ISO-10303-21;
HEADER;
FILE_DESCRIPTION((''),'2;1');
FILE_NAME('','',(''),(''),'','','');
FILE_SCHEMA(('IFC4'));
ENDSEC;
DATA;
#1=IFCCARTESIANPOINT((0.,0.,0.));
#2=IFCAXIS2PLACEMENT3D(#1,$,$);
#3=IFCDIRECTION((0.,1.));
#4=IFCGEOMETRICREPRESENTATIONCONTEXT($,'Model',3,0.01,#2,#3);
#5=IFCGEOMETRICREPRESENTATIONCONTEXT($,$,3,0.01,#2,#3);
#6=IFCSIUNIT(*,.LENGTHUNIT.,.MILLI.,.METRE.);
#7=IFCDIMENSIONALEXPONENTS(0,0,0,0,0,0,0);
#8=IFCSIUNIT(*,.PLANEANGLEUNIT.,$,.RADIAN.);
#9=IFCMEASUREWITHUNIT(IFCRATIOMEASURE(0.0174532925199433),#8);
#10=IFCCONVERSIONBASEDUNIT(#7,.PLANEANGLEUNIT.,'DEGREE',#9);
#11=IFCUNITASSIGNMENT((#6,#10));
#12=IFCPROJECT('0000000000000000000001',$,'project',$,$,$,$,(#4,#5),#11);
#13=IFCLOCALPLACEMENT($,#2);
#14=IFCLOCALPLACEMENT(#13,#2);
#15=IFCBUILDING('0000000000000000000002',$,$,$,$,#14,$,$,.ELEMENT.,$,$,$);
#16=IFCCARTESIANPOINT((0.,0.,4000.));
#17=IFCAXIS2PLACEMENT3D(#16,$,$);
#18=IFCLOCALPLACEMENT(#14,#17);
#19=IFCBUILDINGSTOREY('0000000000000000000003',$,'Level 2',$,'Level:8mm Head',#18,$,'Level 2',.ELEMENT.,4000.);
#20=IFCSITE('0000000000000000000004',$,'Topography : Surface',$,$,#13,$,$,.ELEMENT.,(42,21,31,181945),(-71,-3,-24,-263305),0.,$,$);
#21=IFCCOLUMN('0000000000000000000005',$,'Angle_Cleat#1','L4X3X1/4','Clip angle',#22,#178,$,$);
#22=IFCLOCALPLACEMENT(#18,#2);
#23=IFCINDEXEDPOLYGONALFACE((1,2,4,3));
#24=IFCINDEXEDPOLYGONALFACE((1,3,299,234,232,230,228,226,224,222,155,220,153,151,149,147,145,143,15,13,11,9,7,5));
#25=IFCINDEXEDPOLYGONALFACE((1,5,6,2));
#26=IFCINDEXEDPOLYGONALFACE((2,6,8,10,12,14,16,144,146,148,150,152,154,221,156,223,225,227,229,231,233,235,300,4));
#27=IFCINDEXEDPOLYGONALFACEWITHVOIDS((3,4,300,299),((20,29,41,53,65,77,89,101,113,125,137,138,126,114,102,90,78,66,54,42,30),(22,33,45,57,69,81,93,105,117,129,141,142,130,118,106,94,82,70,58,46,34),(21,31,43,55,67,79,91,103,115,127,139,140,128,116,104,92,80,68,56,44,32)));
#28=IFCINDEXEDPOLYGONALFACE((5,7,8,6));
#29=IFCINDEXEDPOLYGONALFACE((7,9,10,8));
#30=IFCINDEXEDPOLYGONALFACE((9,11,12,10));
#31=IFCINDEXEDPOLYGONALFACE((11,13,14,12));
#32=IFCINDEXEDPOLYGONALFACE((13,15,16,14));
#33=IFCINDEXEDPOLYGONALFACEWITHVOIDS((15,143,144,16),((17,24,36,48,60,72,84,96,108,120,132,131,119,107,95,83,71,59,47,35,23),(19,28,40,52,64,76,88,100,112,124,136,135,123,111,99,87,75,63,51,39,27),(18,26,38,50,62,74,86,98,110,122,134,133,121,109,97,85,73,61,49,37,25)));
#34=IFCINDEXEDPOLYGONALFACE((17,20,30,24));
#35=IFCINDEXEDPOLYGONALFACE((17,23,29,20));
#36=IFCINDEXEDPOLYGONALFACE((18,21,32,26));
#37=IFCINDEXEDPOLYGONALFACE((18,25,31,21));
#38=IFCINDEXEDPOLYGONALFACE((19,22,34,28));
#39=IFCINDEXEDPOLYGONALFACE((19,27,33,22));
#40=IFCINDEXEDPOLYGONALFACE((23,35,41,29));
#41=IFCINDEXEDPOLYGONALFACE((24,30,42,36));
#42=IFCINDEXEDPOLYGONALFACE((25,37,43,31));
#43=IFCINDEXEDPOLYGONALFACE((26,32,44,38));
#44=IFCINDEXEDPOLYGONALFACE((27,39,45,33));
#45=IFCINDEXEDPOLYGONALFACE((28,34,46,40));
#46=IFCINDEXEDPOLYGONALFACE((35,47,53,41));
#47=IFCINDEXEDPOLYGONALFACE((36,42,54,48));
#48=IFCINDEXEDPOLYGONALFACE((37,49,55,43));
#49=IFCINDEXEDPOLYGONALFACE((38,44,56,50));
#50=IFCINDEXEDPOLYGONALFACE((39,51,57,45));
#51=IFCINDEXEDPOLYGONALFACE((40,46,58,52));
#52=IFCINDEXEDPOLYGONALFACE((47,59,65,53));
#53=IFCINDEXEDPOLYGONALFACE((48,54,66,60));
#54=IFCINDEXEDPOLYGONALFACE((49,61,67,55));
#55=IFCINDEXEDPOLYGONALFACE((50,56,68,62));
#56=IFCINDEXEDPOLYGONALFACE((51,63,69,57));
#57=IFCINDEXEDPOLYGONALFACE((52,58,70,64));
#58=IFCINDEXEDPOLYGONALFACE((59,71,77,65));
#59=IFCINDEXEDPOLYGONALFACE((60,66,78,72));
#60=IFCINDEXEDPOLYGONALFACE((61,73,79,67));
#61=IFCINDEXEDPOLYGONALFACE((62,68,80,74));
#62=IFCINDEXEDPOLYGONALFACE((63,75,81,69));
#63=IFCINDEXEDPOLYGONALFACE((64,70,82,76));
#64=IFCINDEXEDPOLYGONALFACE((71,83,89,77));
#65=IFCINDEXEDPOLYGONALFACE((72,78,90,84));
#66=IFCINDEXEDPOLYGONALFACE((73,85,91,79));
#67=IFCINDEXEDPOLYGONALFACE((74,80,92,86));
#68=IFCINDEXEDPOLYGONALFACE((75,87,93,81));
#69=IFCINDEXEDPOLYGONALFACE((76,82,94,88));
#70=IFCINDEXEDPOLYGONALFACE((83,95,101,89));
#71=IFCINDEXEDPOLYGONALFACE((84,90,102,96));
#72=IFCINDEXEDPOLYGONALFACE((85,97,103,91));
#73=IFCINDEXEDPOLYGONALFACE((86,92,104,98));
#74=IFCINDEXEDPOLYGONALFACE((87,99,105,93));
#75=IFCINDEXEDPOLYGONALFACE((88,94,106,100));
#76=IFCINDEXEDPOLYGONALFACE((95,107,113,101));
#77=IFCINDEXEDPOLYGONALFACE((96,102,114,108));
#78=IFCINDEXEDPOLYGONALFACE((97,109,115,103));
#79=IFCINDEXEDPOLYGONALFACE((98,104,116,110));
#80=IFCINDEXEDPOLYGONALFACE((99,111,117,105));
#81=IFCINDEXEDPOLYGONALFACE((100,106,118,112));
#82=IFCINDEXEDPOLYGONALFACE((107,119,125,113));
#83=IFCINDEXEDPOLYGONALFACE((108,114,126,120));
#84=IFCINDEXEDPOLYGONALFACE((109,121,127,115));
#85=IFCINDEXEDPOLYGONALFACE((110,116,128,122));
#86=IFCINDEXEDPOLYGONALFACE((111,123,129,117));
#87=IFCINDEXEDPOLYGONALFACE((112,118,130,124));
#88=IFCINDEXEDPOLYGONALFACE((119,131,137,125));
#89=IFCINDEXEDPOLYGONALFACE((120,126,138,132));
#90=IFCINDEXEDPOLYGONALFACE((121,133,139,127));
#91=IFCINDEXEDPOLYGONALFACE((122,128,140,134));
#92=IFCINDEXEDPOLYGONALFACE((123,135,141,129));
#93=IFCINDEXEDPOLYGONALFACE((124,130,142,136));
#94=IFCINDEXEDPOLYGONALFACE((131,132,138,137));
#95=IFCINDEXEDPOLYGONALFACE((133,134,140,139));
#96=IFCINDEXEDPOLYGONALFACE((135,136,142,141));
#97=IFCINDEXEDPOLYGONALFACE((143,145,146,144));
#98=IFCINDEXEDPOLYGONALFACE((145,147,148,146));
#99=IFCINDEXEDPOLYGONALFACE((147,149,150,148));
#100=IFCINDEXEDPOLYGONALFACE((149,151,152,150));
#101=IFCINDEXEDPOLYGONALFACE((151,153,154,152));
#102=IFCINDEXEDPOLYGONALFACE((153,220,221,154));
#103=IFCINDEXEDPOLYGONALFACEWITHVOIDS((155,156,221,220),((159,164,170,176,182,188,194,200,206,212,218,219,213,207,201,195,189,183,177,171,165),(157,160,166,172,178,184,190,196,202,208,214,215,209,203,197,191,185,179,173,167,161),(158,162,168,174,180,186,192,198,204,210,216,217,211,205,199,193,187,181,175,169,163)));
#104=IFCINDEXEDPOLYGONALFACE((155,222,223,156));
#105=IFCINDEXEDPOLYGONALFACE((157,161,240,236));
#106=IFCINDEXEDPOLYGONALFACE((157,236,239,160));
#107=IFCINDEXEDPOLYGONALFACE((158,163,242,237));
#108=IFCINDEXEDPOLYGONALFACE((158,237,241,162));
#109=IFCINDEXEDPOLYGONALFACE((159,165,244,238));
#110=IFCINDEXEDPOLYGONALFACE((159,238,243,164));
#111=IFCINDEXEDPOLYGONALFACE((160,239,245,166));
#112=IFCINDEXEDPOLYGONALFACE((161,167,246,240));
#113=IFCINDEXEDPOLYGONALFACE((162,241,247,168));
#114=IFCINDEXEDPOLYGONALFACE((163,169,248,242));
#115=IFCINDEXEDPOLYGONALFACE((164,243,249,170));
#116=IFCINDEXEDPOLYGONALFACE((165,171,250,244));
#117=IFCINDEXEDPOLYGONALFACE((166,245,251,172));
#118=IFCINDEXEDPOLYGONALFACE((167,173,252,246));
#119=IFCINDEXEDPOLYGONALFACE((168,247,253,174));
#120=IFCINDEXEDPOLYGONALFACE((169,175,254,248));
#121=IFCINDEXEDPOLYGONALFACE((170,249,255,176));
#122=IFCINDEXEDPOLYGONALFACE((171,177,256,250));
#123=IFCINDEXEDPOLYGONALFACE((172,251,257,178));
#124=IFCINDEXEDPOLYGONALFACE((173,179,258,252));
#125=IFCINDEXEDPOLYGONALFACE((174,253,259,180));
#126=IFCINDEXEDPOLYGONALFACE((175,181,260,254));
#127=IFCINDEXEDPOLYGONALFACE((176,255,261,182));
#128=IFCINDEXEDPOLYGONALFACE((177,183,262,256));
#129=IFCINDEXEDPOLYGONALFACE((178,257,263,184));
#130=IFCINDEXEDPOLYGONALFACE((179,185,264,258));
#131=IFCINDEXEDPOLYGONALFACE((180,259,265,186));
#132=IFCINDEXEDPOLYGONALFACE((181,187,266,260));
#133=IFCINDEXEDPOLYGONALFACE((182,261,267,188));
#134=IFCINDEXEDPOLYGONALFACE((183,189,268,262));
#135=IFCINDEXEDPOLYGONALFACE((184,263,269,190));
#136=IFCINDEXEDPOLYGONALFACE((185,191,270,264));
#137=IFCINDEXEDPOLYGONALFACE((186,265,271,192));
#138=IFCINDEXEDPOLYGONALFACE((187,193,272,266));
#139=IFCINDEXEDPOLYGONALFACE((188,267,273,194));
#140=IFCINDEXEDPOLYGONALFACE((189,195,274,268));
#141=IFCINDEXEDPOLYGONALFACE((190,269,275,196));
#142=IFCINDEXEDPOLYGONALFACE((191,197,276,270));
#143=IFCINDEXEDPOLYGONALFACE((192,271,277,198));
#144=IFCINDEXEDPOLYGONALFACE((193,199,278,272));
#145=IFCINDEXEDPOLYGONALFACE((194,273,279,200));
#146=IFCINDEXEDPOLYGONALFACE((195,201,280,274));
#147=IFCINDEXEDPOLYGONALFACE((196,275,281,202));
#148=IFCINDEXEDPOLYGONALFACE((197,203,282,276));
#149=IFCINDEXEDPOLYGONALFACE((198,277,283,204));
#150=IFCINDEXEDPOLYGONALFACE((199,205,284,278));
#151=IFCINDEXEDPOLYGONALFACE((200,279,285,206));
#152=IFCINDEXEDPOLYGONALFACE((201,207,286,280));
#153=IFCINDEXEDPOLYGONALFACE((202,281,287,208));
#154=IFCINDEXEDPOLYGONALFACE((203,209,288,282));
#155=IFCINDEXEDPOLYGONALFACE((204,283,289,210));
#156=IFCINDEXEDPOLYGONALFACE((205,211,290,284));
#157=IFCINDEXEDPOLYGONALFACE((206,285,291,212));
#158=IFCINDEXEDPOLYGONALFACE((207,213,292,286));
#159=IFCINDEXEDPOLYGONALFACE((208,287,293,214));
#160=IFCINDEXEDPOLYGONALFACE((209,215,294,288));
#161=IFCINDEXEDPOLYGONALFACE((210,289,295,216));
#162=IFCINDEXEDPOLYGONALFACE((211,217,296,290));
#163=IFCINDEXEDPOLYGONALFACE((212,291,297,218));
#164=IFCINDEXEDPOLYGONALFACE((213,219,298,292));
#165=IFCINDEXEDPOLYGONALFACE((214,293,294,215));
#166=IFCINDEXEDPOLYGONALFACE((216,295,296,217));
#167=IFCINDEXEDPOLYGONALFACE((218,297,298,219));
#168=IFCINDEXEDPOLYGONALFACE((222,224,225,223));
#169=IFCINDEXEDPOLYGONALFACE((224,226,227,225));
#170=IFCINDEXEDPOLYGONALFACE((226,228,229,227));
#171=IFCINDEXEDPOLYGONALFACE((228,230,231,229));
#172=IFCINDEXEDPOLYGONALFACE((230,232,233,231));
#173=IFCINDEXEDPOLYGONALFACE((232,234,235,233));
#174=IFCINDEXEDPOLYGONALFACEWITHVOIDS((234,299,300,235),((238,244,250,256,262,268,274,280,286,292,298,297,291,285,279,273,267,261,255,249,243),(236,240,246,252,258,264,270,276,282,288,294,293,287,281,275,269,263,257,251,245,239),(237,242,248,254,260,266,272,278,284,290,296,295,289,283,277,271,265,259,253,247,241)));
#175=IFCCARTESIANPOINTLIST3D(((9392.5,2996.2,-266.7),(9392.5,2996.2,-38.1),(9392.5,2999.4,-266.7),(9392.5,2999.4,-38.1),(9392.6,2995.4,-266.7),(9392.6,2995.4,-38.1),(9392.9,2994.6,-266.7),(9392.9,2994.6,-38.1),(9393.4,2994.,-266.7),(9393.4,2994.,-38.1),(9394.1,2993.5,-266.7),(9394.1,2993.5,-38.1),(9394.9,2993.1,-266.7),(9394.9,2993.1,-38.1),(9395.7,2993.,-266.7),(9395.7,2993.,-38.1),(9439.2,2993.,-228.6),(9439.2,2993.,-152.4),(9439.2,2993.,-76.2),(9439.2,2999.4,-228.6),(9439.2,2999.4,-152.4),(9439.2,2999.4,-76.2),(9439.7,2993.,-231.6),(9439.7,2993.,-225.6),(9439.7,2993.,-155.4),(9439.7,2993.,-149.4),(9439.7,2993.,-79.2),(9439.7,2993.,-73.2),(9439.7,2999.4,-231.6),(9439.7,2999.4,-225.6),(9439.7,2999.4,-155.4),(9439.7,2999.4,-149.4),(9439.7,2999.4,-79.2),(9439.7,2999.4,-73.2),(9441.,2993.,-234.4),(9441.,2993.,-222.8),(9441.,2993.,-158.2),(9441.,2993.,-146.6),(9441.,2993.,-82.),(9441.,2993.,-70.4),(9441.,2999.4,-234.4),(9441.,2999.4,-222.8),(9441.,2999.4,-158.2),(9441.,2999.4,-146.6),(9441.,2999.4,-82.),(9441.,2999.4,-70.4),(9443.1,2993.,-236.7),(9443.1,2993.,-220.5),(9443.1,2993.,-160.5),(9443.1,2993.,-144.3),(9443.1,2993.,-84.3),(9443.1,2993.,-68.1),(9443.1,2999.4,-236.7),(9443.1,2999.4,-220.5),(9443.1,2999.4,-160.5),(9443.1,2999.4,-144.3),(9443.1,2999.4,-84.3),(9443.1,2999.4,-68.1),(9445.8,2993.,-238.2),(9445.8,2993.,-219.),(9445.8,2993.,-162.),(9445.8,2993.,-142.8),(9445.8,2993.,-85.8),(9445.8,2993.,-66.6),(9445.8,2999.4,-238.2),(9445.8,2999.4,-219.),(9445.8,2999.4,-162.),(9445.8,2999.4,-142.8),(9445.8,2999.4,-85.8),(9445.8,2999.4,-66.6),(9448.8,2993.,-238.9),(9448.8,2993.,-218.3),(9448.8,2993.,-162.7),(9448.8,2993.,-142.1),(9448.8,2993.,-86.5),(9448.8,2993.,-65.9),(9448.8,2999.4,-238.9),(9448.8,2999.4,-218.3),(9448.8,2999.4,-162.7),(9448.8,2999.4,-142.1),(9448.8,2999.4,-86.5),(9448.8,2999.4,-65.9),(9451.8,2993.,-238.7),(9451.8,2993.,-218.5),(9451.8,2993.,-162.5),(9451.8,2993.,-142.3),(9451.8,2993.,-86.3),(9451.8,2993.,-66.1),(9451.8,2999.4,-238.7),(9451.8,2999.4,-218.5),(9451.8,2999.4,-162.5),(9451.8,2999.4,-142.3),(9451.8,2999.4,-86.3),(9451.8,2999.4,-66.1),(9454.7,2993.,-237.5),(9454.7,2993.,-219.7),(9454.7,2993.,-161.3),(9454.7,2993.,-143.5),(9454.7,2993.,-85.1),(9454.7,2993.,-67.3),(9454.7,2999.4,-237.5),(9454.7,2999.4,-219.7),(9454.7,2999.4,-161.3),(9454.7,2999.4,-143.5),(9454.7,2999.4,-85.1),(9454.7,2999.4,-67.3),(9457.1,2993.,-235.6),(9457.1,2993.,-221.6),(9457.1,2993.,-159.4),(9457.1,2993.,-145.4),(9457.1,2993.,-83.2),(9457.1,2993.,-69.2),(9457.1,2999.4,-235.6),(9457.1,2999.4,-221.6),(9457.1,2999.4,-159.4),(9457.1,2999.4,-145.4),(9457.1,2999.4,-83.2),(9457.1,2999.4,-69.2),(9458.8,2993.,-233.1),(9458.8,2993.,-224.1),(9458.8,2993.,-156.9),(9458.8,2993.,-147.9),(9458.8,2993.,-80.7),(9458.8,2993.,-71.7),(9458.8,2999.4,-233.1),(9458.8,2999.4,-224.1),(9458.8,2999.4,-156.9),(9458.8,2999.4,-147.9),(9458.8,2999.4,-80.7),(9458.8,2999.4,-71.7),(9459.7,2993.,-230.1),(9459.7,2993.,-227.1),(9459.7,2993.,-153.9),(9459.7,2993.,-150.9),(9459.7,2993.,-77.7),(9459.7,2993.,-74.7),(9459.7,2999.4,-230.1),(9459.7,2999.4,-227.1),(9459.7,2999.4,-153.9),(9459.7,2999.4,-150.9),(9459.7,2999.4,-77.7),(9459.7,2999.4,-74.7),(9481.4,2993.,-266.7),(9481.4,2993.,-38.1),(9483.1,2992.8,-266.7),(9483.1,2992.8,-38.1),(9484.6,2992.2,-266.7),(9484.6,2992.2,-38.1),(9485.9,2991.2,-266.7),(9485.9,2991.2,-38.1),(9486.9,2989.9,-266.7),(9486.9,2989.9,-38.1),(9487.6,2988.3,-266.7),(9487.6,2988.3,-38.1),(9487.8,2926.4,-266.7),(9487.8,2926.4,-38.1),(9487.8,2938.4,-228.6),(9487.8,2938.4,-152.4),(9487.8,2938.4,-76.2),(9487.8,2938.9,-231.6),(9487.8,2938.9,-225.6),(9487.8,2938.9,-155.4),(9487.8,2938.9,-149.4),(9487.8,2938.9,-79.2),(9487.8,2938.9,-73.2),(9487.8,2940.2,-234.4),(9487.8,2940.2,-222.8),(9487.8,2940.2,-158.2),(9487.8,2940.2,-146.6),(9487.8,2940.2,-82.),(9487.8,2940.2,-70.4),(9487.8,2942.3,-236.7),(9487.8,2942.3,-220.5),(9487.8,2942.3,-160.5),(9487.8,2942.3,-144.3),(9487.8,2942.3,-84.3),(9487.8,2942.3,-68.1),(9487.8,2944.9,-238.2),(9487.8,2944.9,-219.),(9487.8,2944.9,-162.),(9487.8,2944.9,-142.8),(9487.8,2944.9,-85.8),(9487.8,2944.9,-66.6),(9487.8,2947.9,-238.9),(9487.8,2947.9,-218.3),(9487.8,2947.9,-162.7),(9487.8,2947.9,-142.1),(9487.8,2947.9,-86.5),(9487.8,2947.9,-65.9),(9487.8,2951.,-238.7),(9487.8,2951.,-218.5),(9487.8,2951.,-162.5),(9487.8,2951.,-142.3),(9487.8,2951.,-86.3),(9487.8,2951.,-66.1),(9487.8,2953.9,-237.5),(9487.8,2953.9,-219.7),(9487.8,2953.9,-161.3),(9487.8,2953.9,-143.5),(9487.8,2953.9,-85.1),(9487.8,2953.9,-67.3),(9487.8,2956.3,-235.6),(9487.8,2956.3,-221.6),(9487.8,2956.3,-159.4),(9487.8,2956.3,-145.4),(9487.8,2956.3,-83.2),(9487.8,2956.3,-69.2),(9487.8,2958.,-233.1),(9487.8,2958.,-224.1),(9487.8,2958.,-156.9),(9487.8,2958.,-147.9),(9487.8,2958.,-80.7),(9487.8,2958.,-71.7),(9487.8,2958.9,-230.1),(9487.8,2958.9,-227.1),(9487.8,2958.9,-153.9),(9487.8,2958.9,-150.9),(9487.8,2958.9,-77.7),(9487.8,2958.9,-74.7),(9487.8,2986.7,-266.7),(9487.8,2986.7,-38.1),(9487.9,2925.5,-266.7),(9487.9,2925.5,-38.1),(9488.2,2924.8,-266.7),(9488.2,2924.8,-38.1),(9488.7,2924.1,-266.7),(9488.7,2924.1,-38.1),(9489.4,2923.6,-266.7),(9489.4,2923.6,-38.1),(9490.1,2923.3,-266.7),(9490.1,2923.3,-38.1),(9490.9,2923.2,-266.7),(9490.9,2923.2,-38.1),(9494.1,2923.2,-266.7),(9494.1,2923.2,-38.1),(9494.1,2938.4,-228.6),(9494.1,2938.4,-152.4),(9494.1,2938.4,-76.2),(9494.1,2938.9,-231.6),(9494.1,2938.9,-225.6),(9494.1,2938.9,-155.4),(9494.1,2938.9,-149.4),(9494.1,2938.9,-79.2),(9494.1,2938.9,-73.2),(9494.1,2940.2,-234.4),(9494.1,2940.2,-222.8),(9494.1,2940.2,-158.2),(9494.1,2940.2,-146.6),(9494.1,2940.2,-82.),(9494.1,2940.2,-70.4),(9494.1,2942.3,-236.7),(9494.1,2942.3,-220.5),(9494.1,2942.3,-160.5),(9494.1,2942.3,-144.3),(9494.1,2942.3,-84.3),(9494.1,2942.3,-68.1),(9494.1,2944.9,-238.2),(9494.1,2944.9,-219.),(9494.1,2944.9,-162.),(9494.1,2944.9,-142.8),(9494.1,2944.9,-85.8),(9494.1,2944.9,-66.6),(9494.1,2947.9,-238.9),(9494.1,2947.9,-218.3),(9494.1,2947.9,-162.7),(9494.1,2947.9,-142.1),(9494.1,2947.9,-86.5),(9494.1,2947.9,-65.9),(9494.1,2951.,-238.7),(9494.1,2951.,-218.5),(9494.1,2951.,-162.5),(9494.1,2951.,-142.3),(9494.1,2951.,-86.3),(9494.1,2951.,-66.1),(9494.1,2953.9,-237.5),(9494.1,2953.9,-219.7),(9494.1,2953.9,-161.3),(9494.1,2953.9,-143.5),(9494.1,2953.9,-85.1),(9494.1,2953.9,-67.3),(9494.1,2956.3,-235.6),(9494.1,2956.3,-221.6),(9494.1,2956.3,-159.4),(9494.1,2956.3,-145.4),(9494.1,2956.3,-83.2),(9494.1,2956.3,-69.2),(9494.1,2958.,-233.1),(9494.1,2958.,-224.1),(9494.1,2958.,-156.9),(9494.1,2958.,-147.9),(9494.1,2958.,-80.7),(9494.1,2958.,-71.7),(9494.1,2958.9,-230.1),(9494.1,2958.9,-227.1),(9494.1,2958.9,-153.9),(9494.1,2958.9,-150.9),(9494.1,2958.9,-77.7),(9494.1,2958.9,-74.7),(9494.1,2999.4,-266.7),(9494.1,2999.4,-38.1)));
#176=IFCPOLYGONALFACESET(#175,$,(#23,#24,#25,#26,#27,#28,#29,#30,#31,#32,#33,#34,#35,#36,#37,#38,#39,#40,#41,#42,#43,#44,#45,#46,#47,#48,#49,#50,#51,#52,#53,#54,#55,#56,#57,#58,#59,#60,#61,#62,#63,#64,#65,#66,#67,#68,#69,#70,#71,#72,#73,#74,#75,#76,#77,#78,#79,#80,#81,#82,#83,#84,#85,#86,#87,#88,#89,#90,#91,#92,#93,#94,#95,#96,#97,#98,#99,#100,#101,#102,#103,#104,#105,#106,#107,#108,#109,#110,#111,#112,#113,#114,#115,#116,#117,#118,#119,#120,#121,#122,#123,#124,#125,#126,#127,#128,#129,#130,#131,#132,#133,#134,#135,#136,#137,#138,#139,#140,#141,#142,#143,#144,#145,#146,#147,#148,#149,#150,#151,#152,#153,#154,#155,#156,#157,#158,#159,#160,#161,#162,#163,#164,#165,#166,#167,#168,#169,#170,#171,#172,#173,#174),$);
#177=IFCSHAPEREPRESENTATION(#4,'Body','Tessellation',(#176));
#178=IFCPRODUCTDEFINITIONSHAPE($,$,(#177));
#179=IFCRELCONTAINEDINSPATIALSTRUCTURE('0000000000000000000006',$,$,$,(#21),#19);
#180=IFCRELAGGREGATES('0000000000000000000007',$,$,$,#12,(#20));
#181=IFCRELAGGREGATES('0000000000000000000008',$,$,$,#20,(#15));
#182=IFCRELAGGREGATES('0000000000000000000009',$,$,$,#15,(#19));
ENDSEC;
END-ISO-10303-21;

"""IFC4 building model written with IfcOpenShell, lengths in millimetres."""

from ifc_helpers import new_model, entity, si_unit, converted_unit, direction, frame, frame_2d, origin, origin_2d_with_axis, place, context, project, spatial, circle, l_section, extrude, element, save


model = new_model("IFC4")

# Units and contexts
model_context = context("Model", 3, precision=0.01, world=origin(), true_north=direction((0.0, 1.0)))
context_of_model = context(None, 3, precision=0.01, world=origin(), true_north=direction((0.0, 1.0)))
ifc_project = project(units=[si_unit("LENGTHUNIT", "METRE", prefix="MILLI"), converted_unit("PLANEANGLEUNIT", "DEGREE", entity("IfcRatioMeasure", 0.0174532925199433), si_unit("PLANEANGLEUNIT", "RADIAN"), dimensions=[0, 0, 0, 0, 0, 0, 0])], contexts=[model_context, context_of_model])

# Site, building, storey
site_placement = place(None, origin())
site = spatial("IfcSite", under=ifc_project, at=site_placement, Name="Topography : Surface", CompositionType="ELEMENT", RefLatitude=(42, 21, 31, 181945), RefLongitude=(-71, -3, -24, -263305), RefElevation=0.0)
building_placement = place(site_placement, origin())
building = spatial("IfcBuilding", under=site, at=building_placement, CompositionType="ELEMENT")
storey_placement = place(building_placement, frame((0.0, 0.0, 4000.0)))
storey = spatial("IfcBuildingStorey", under=building, at=storey_placement, Name="Level 2", ObjectType="Level:8mm Head", LongName="Level 2", CompositionType="ELEMENT", Elevation=4000.0)

# Column, openings
column_1_placement = place(storey_placement, frame((9463.0, 2981.1, -266.7), z_axis=(0.0, 0.0, -1.0), x_axis=(0.0, -1.0, 0.0)))
column_1 = element("IfcColumn", 1, at=column_1_placement, inside=storey, Name="Angle_Cleat#1", Description="L4X3X1/4", ObjectType="Clip angle", context=model_context, shape_type="SweptSolid", body=[
    extrude(l_section(Depth=101.6, Width=76.2, Thickness=6.3, FilletRadius=6.3, EdgeRadius=3.2, at=frame_2d((19.8, 19.7))), origin(), (0.0, 0.0, -1.0), 228.6),
])
opening_1_placement = place(column_1_placement, frame((32.4, -31.5, -114.3), z_axis=(0.0, 1.0, 0.0), x_axis=(1.0, 0.0, 0.0)))
element("IfcOpeningElement", 2, at=opening_1_placement, cuts=column_1, ObjectType="Opening", context=model_context, shape_type="SweptSolid", body=[
    extrude(circle(Radius=10.3, at=origin_2d_with_axis()), origin(), (0.0, 0.0, 1.0), 7.3),
])
opening_2_placement = place(column_1_placement, frame((32.4, -31.5, -114.3), z_axis=(0.0, 1.0, 0.0), x_axis=(1.0, 0.0, 0.0)))
element("IfcOpeningElement", 3, at=opening_2_placement, cuts=column_1, ObjectType="Opening", context=model_context, shape_type="SweptSolid", body=[
    extrude(circle(Radius=10.3, at=frame_2d((0.0, 76.2), x_axis=(1.0, 0.0))), origin(), (0.0, 0.0, 1.0), 7.3),
])
opening_3_placement = place(column_1_placement, frame((32.4, -31.5, -114.3), z_axis=(0.0, 1.0, 0.0), x_axis=(1.0, 0.0, 0.0)))
element("IfcOpeningElement", 4, at=opening_3_placement, cuts=column_1, ObjectType="Opening", context=model_context, shape_type="SweptSolid", body=[
    extrude(circle(Radius=10.3, at=frame_2d((0.0, -76.2), x_axis=(1.0, 0.0))), origin(), (0.0, 0.0, 1.0), 7.3),
])
opening_4_placement = place(column_1_placement, frame((-18.9, 13.5, -114.3), z_axis=(1.0, 0.0, 0.0), x_axis=(0.0, 1.0, 0.0)))
element("IfcOpeningElement", 5, at=opening_4_placement, cuts=column_1, ObjectType="Opening", context=model_context, shape_type="SweptSolid", body=[
    extrude(circle(Radius=10.3, at=origin_2d_with_axis()), origin(), (0.0, 0.0, 1.0), 7.3),
])
opening_5_placement = place(column_1_placement, frame((-18.9, 13.5, -114.3), z_axis=(1.0, 0.0, 0.0), x_axis=(0.0, 1.0, 0.0)))
element("IfcOpeningElement", 6, at=opening_5_placement, cuts=column_1, ObjectType="Opening", context=model_context, shape_type="SweptSolid", body=[
    extrude(circle(Radius=10.3, at=frame_2d((0.0, 76.2), x_axis=(1.0, 0.0))), origin(), (0.0, 0.0, 1.0), 7.3),
])
opening_6_placement = place(column_1_placement, frame((-18.9, 13.5, -114.3), z_axis=(1.0, 0.0, 0.0), x_axis=(0.0, 1.0, 0.0)))
element("IfcOpeningElement", 7, at=opening_6_placement, cuts=column_1, ObjectType="Opening", context=model_context, shape_type="SweptSolid", body=[
    extrude(circle(Radius=10.3, at=frame_2d((0.0, -76.2), x_axis=(1.0, 0.0))), origin(), (0.0, 0.0, 1.0), 7.3),
])

save(model, "model.ifc")
